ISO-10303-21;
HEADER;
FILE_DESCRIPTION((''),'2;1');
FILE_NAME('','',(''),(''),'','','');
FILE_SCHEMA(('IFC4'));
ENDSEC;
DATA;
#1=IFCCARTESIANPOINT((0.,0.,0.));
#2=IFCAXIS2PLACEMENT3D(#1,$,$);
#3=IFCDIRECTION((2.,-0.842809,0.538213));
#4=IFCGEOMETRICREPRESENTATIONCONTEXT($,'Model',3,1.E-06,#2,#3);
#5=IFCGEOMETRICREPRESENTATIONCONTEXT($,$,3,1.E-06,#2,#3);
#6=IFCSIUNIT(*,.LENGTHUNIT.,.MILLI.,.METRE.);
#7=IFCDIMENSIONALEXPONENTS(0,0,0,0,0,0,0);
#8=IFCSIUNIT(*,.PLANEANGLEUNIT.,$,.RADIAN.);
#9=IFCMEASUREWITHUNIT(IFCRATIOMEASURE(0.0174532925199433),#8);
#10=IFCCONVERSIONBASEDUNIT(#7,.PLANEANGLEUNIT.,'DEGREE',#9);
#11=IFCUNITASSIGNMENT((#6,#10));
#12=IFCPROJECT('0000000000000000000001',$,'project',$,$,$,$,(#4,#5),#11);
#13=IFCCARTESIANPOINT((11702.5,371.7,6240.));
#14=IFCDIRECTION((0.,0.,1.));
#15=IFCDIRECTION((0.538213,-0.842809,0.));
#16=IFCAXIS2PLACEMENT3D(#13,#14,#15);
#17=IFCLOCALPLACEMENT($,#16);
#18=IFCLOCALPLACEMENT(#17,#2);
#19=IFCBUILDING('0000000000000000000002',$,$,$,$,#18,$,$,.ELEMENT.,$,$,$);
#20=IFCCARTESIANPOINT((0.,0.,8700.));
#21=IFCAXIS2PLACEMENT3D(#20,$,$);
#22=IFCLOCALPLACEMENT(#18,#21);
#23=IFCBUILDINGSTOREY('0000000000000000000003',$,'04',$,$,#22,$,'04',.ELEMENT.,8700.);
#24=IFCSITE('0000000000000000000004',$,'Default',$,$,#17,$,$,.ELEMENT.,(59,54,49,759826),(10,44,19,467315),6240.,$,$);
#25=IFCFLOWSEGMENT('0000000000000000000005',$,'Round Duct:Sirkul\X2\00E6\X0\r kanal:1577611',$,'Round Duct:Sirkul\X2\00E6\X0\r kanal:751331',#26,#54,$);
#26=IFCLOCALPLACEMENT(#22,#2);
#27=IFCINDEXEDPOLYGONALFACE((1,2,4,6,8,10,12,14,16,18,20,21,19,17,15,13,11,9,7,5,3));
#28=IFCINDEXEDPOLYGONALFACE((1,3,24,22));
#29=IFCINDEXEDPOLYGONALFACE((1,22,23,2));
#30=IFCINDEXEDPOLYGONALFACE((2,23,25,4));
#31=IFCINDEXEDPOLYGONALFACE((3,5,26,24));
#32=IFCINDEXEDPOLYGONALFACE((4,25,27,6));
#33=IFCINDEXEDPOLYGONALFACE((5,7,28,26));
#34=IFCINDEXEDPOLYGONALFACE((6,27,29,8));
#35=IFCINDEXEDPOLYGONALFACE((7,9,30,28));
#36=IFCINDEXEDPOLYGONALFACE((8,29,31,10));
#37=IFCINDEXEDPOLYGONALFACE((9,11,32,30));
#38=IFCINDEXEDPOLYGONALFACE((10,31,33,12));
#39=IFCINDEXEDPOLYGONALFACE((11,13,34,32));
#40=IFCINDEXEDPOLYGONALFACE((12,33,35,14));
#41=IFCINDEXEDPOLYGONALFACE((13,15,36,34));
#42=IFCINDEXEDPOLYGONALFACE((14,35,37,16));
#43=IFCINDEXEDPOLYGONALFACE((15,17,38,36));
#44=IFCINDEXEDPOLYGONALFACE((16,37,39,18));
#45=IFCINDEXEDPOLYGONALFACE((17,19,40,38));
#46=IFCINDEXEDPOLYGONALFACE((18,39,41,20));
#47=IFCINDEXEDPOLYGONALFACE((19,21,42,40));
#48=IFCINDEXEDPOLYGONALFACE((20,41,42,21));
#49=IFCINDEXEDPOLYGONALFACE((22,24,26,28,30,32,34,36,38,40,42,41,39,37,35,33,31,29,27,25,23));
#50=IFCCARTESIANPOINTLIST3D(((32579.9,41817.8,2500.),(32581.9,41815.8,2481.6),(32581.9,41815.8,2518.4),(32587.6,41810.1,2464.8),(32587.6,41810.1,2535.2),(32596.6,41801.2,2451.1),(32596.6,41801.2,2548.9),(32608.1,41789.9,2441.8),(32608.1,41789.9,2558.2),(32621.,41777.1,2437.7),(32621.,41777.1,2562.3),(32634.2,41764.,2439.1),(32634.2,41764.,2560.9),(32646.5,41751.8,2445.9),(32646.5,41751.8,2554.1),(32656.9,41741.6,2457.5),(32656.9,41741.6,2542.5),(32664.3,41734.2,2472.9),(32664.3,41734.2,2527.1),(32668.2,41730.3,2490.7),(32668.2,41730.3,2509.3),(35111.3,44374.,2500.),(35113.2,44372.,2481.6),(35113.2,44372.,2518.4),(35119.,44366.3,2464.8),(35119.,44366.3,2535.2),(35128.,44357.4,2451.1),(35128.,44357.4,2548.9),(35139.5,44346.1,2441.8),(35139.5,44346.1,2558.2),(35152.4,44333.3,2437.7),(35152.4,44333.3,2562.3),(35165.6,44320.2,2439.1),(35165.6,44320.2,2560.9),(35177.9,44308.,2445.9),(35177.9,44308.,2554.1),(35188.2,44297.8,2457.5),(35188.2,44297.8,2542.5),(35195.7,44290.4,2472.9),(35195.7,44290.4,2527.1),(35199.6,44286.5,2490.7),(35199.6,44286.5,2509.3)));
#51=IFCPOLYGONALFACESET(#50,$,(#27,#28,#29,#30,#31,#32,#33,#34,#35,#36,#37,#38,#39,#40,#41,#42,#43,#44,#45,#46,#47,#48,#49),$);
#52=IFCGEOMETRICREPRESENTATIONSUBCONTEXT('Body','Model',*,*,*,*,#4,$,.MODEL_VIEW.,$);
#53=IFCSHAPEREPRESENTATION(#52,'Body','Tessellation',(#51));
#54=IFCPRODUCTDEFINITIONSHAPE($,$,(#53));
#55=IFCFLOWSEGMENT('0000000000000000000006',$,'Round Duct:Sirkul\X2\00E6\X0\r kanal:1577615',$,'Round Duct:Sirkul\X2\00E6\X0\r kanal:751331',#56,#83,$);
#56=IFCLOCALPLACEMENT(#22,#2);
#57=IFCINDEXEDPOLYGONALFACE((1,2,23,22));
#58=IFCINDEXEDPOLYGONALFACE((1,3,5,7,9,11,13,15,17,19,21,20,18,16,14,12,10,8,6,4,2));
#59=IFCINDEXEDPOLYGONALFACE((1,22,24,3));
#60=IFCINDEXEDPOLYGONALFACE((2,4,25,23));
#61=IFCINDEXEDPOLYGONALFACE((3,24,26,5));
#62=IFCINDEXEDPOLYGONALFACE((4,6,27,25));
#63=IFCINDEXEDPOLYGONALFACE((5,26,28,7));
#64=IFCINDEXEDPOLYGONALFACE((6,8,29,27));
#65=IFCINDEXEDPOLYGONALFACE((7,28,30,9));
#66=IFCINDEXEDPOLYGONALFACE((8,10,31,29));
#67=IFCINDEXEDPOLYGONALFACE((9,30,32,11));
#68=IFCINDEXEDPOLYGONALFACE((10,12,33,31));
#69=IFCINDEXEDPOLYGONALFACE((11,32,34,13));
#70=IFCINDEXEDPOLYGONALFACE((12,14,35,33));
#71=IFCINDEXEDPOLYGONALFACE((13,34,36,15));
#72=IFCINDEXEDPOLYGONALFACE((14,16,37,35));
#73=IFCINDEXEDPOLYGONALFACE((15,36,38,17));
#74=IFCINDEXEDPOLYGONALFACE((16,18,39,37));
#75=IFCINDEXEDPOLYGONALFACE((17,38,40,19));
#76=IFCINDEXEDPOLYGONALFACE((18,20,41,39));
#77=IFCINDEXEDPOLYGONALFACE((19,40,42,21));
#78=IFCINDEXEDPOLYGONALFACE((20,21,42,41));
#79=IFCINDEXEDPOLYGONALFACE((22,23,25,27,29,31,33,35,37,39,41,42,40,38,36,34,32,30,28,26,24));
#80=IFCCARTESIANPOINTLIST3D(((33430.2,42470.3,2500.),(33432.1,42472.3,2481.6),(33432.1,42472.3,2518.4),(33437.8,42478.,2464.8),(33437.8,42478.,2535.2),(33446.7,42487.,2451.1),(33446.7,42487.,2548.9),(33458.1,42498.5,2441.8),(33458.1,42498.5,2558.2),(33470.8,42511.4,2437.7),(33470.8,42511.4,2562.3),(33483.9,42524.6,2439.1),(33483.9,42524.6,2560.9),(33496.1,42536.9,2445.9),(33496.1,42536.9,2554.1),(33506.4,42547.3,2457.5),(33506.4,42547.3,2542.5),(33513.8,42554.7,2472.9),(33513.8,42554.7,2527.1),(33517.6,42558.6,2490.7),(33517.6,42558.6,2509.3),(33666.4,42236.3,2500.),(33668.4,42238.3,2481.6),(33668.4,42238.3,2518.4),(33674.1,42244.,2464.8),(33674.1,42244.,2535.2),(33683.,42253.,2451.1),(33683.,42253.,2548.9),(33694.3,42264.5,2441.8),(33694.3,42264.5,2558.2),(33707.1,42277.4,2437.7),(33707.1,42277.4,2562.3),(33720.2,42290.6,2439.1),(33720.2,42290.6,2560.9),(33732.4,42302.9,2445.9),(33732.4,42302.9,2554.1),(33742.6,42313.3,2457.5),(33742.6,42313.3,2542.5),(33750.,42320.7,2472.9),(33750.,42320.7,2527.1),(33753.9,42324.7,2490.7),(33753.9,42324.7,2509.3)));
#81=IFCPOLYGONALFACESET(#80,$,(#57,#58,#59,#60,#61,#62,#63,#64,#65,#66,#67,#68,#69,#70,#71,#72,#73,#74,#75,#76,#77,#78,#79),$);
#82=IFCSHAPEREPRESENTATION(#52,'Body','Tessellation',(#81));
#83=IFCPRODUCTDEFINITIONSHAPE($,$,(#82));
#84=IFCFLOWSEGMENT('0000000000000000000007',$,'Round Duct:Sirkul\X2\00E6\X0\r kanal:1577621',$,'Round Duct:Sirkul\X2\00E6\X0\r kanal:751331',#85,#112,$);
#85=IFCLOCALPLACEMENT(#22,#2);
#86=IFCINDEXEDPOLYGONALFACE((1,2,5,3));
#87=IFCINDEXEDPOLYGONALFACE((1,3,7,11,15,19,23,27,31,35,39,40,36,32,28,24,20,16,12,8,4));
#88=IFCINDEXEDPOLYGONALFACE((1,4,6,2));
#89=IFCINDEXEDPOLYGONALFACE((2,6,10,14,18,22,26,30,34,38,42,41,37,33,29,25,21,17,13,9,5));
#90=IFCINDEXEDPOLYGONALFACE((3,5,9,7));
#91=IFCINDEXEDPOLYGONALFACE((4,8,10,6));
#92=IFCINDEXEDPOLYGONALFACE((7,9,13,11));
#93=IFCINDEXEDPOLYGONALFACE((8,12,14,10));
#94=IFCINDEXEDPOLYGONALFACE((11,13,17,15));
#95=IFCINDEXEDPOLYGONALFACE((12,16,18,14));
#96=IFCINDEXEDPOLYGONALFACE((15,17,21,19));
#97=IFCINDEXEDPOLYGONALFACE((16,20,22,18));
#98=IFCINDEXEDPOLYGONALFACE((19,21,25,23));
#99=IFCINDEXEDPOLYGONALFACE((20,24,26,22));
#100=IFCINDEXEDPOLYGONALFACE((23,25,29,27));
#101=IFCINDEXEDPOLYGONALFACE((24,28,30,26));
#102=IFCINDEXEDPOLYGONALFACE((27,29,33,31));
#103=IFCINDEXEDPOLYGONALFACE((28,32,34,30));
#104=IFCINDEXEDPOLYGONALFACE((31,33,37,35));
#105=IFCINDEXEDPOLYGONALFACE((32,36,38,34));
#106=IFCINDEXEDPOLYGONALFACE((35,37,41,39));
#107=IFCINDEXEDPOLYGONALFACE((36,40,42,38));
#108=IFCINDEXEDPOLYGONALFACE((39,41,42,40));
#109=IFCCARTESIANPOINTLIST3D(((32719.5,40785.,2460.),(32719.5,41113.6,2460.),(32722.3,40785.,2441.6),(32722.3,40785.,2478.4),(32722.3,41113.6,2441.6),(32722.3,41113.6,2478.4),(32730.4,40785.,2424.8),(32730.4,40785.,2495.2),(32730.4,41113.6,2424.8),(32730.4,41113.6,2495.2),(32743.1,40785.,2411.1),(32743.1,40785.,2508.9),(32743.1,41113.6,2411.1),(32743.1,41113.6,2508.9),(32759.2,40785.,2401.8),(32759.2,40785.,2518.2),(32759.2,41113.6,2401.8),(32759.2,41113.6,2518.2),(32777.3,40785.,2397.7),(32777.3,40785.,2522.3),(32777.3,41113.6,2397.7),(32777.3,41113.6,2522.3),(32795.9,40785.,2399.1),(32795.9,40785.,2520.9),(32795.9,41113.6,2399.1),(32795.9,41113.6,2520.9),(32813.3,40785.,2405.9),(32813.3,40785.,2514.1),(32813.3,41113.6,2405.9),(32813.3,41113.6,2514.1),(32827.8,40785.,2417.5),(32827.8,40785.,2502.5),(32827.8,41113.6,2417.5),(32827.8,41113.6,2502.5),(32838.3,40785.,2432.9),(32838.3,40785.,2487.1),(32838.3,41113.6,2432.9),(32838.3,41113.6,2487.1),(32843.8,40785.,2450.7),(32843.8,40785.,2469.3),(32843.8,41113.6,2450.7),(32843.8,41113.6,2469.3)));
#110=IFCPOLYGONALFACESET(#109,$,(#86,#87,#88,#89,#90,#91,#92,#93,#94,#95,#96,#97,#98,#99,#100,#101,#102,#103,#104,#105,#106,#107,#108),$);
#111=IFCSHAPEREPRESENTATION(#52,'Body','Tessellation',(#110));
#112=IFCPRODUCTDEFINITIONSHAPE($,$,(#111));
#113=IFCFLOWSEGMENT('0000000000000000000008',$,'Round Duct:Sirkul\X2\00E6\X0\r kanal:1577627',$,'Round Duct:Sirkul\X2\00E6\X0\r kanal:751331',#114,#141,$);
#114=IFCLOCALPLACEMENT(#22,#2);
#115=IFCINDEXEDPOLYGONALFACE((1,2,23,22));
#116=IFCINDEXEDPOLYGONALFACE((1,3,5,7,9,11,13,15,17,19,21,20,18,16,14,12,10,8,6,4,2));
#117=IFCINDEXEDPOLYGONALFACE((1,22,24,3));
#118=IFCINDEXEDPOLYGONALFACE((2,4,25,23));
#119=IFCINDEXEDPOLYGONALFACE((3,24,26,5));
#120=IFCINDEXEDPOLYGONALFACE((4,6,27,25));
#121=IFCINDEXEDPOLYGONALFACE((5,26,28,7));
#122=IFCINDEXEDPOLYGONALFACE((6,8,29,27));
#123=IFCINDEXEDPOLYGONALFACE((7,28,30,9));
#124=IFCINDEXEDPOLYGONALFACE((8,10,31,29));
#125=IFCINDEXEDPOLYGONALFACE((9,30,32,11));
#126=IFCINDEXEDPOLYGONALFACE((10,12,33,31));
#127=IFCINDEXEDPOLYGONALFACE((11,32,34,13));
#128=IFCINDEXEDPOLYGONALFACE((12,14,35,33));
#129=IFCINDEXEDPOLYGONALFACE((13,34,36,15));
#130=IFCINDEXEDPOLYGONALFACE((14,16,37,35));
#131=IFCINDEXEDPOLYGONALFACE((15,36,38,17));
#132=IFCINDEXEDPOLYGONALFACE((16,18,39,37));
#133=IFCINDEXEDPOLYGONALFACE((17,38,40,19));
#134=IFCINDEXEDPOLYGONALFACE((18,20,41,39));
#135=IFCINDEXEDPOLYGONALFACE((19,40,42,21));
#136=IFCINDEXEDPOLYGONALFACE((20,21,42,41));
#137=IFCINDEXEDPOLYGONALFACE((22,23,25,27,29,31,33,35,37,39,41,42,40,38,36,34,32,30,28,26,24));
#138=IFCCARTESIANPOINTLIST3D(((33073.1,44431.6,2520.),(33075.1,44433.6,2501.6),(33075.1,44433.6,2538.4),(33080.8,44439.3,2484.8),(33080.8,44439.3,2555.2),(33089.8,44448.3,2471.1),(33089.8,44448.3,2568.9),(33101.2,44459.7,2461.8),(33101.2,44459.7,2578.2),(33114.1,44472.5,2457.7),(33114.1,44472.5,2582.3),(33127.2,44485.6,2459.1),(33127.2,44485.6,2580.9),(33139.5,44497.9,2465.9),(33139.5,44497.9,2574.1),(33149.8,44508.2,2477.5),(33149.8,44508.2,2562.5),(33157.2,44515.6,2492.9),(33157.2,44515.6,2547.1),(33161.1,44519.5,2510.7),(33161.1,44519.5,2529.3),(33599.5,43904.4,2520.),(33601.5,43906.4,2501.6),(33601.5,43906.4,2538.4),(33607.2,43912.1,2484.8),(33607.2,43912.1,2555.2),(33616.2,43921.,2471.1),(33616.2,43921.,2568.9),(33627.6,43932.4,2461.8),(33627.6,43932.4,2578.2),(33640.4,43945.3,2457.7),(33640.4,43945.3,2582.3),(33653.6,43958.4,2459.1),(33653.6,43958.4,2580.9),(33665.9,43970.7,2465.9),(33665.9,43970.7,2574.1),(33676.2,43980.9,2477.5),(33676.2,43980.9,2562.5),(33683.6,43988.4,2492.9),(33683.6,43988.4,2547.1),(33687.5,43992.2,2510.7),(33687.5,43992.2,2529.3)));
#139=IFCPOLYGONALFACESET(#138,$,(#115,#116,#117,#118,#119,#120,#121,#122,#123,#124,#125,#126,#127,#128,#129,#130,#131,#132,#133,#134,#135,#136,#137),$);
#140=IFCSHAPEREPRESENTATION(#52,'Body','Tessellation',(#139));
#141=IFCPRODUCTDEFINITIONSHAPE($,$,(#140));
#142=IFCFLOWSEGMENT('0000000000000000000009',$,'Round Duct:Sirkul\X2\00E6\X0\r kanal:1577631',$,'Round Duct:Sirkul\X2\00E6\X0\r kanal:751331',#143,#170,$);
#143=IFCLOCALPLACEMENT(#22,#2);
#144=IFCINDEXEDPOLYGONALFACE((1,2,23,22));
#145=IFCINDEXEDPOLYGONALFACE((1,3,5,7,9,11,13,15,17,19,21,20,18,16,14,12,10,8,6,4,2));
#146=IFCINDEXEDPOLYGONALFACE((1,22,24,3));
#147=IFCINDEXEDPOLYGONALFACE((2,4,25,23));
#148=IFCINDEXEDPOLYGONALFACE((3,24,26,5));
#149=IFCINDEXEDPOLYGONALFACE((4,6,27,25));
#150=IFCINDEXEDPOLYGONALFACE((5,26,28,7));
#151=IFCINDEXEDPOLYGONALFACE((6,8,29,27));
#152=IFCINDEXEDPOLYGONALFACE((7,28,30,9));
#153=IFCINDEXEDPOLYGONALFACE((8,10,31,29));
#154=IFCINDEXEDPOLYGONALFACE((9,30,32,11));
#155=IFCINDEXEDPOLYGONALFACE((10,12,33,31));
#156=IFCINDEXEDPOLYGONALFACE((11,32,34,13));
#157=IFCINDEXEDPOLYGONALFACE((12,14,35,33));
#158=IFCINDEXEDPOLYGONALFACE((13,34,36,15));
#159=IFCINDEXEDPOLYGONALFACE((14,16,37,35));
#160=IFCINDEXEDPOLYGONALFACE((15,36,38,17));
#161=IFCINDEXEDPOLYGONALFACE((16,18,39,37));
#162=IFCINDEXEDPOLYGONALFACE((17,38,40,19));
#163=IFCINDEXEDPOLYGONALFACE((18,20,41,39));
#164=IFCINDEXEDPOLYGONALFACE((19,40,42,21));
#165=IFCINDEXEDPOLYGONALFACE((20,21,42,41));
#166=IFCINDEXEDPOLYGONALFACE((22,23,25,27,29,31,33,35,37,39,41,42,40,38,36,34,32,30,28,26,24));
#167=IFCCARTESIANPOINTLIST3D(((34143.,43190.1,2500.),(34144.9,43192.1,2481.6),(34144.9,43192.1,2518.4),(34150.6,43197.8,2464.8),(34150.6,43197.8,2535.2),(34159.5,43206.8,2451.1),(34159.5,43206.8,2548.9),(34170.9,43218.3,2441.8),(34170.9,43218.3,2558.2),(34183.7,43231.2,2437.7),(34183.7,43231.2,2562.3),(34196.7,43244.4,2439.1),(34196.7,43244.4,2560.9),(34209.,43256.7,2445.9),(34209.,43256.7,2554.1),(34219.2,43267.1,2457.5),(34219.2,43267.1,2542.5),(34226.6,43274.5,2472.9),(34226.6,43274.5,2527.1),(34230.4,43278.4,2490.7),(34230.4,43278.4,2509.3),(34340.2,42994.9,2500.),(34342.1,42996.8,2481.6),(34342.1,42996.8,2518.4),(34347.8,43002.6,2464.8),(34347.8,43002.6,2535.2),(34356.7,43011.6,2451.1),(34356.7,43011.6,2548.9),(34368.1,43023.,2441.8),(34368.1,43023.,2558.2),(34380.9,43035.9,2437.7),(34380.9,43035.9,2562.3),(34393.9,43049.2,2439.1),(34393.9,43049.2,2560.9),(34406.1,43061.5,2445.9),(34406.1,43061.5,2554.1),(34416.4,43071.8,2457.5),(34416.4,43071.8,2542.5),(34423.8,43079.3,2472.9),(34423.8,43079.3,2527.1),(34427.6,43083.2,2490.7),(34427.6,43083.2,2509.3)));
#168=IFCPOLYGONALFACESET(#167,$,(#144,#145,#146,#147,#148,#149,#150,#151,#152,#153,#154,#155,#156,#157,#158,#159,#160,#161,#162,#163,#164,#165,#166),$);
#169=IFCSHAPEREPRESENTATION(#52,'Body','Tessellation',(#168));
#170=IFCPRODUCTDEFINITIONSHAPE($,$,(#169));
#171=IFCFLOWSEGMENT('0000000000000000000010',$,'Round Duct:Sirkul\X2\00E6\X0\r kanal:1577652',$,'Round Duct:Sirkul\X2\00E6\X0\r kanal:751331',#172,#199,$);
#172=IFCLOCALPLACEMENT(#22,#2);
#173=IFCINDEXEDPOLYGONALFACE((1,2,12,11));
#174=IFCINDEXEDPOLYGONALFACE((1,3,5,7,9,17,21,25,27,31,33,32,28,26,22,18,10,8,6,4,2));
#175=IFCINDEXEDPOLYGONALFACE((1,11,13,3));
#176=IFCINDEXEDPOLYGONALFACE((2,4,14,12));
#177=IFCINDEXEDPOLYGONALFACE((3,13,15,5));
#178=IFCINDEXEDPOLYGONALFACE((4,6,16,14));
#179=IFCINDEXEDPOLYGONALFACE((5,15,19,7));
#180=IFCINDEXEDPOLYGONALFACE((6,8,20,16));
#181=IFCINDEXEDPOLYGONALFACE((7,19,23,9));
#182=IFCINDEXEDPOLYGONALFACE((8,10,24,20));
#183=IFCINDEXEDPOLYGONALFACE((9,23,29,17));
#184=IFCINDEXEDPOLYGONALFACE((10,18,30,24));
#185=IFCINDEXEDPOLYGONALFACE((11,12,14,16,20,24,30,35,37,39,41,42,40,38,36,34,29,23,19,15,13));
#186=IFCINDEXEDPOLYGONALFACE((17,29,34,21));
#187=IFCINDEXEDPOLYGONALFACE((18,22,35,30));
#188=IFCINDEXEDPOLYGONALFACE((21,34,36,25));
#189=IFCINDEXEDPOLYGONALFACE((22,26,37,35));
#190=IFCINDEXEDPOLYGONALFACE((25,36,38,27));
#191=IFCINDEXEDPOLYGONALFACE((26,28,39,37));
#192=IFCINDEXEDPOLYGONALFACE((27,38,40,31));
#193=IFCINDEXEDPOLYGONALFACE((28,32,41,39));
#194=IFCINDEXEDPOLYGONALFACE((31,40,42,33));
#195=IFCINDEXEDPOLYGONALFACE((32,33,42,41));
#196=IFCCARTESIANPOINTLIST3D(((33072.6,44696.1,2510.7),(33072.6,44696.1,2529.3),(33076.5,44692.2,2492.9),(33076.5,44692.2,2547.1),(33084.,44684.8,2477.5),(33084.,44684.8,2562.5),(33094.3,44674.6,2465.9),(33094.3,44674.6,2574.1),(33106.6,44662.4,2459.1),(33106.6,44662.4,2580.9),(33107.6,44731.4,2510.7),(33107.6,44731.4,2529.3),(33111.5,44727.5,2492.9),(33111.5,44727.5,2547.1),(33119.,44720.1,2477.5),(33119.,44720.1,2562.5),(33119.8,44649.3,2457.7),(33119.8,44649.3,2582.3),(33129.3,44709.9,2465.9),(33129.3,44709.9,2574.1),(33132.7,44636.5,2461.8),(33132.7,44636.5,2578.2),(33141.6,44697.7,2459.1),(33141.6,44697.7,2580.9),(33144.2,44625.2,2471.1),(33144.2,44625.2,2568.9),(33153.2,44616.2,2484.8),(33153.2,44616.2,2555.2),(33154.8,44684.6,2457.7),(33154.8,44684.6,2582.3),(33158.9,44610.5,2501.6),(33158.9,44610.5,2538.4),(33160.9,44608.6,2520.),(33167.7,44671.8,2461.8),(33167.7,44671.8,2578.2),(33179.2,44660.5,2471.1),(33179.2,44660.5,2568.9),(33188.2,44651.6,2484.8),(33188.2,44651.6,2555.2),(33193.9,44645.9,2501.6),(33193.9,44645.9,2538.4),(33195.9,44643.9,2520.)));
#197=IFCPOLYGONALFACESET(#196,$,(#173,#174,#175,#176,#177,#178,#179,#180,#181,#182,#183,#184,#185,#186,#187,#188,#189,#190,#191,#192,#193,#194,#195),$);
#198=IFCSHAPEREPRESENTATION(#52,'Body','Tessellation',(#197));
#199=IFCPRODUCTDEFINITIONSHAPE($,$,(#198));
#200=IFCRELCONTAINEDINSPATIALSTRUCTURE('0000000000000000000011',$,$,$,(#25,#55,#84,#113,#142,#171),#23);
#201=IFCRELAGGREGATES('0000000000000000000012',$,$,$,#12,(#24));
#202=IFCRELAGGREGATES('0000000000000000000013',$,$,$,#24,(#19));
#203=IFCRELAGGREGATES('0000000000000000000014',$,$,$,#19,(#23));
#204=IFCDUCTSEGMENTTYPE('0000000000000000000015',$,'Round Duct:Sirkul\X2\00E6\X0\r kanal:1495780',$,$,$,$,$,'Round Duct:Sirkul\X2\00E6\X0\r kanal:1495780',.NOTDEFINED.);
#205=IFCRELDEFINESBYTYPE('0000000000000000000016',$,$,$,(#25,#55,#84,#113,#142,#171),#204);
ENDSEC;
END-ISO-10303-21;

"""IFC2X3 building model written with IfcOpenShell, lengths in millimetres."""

from ifc_helpers import new_model, entity, si_unit, converted_unit, direction, frame, frame_2d, origin, origin_2d_with_axis, place, context, subcontext, project, spatial, circle, extrude, type_object, element, save


model = new_model("IFC2X3")

# Units and contexts
model_context = context("Model", 3, precision=1e-06, world=origin(), true_north=direction((2.0, -0.842809, 0.538213)))
context_of_model = context(None, 3, precision=1e-06, world=origin(), true_north=direction((2.0, -0.842809, 0.538213)))
body_context = subcontext(model_context, "Body", "Model", "MODEL_VIEW")
ifc_project = project(units=[si_unit("LENGTHUNIT", "METRE", prefix="MILLI"), converted_unit("PLANEANGLEUNIT", "DEGREE", entity("IfcRatioMeasure", 0.0174532925199433), si_unit("PLANEANGLEUNIT", "RADIAN"), dimensions=[0, 0, 0, 0, 0, 0, 0])], contexts=[model_context, context_of_model])

# Site, building, storey
site_placement = place(None, frame((11702.5, 371.7, 6240.0), z_axis=(0.0, 0.0, 1.0), x_axis=(0.538213, -0.842809, 0.0)))
site = spatial("IfcSite", under=ifc_project, at=site_placement, Name="Default", CompositionType="ELEMENT", RefLatitude=(59, 54, 49, 759826), RefLongitude=(10, 44, 19, 467315), RefElevation=6240.0)
building_placement = place(site_placement, origin())
building = spatial("IfcBuilding", under=site, at=building_placement, CompositionType="ELEMENT")
storey_placement = place(building_placement, frame((0.0, 0.0, 8700.0)))
storey = spatial("IfcBuildingStorey", under=building, at=storey_placement, Name="04", LongName="04", CompositionType="ELEMENT", Elevation=8700.0)

# Flow segments
duct_segment_type = type_object("IfcDuctSegmentType", Name="Round Duct:Sirkulær kanal:1495780", ElementType="Round Duct:Sirkulær kanal:1495780", PredefinedType="NOTDEFINED")
flow_segment_1_placement = place(storey_placement, origin())
element("IfcFlowSegment", 1, at=flow_segment_1_placement, inside=storey, type_object=duct_segment_type, Name="Round Duct:Sirkulær kanal:1577611", ObjectType="Round Duct:Sirkulær kanal:751331", context=body_context, shape_type="SweptSolid", body=[
    extrude(circle(Radius=62.5, at=frame_2d((0.0, 0.0), x_axis=(1.0, 0.0))), frame((32624.3, 41773.8, 2500.0), z_axis=(0.703643, 0.710554, 0.0), x_axis=(-0.710554, 0.703643, 0.0)), (0.0, 0.0, 1.0), 3597.5),
])
flow_segment_2_placement = place(storey_placement, origin())
element("IfcFlowSegment", 2, at=flow_segment_2_placement, inside=storey, type_object=duct_segment_type, Name="Round Duct:Sirkulær kanal:1577615", ObjectType="Round Duct:Sirkulær kanal:751331", context=body_context, shape_type="SweptSolid", body=[
    extrude(circle(Radius=62.5, at=origin_2d_with_axis()), frame((33710.4, 42280.7, 2500.0), z_axis=(-0.710554, 0.703643, 0.0), x_axis=(-0.703643, -0.710554, 0.0)), (0.0, 0.0, 1.0), 332.5),
])
flow_segment_3_placement = place(storey_placement, origin())
element("IfcFlowSegment", 3, at=flow_segment_3_placement, inside=storey, type_object=duct_segment_type, Name="Round Duct:Sirkulær kanal:1577621", ObjectType="Round Duct:Sirkulær kanal:751331", context=body_context, shape_type="SweptSolid", body=[
    extrude(circle(Radius=62.5, at=frame_2d((0.0, 0.0), x_axis=(1.0, 0.0))), frame((32782.0, 40785.0, 2460.0), z_axis=(0.0, 1.0, 0.0), x_axis=(-1.0, 0.0, 0.0)), (0.0, 0.0, 1.0), 328.6),
])
flow_segment_4_placement = place(storey_placement, origin())
element("IfcFlowSegment", 4, at=flow_segment_4_placement, inside=storey, type_object=duct_segment_type, Name="Round Duct:Sirkulær kanal:1577627", ObjectType="Round Duct:Sirkulær kanal:751331", context=body_context, shape_type="SweptSolid", body=[
    extrude(circle(Radius=62.5, at=origin_2d_with_axis()), frame((33117.4, 44475.8, 2520.0), z_axis=(0.706527, -0.707686, 0.0), x_axis=(-0.707686, -0.706527, 0.0)), (0.0, 0.0, 1.0), 745.0),
])
flow_segment_5_placement = place(storey_placement, origin())
element("IfcFlowSegment", 5, at=flow_segment_5_placement, inside=storey, type_object=duct_segment_type, Name="Round Duct:Sirkulær kanal:1577631", ObjectType="Round Duct:Sirkulær kanal:751331", context=body_context, shape_type="SweptSolid", body=[
    extrude(circle(Radius=62.5, at=frame_2d((0.0, 0.0), x_axis=(1.0, 0.0))), frame((34187.0, 43234.5, 2500.0), z_axis=(0.710554, -0.703643, 0.0), x_axis=(-0.703643, -0.710554, 0.0)), (0.0, 0.0, 1.0), 277.5),
])
flow_segment_6_placement = place(storey_placement, origin())
element("IfcFlowSegment", 6, at=flow_segment_6_placement, inside=storey, type_object=duct_segment_type, Name="Round Duct:Sirkulær kanal:1577652", ObjectType="Round Duct:Sirkulær kanal:751331", context=body_context, shape_type="SweptSolid", body=[
    extrude(circle(Radius=62.5, at=origin_2d_with_axis()), frame((33116.5, 44652.6, 2520.0), z_axis=(0.703643, 0.710554, 0.0), x_axis=(0.710554, -0.703643, 0.0)), (0.0, 0.0, 1.0), 49.7),
])

save(model, "model.ifc")
